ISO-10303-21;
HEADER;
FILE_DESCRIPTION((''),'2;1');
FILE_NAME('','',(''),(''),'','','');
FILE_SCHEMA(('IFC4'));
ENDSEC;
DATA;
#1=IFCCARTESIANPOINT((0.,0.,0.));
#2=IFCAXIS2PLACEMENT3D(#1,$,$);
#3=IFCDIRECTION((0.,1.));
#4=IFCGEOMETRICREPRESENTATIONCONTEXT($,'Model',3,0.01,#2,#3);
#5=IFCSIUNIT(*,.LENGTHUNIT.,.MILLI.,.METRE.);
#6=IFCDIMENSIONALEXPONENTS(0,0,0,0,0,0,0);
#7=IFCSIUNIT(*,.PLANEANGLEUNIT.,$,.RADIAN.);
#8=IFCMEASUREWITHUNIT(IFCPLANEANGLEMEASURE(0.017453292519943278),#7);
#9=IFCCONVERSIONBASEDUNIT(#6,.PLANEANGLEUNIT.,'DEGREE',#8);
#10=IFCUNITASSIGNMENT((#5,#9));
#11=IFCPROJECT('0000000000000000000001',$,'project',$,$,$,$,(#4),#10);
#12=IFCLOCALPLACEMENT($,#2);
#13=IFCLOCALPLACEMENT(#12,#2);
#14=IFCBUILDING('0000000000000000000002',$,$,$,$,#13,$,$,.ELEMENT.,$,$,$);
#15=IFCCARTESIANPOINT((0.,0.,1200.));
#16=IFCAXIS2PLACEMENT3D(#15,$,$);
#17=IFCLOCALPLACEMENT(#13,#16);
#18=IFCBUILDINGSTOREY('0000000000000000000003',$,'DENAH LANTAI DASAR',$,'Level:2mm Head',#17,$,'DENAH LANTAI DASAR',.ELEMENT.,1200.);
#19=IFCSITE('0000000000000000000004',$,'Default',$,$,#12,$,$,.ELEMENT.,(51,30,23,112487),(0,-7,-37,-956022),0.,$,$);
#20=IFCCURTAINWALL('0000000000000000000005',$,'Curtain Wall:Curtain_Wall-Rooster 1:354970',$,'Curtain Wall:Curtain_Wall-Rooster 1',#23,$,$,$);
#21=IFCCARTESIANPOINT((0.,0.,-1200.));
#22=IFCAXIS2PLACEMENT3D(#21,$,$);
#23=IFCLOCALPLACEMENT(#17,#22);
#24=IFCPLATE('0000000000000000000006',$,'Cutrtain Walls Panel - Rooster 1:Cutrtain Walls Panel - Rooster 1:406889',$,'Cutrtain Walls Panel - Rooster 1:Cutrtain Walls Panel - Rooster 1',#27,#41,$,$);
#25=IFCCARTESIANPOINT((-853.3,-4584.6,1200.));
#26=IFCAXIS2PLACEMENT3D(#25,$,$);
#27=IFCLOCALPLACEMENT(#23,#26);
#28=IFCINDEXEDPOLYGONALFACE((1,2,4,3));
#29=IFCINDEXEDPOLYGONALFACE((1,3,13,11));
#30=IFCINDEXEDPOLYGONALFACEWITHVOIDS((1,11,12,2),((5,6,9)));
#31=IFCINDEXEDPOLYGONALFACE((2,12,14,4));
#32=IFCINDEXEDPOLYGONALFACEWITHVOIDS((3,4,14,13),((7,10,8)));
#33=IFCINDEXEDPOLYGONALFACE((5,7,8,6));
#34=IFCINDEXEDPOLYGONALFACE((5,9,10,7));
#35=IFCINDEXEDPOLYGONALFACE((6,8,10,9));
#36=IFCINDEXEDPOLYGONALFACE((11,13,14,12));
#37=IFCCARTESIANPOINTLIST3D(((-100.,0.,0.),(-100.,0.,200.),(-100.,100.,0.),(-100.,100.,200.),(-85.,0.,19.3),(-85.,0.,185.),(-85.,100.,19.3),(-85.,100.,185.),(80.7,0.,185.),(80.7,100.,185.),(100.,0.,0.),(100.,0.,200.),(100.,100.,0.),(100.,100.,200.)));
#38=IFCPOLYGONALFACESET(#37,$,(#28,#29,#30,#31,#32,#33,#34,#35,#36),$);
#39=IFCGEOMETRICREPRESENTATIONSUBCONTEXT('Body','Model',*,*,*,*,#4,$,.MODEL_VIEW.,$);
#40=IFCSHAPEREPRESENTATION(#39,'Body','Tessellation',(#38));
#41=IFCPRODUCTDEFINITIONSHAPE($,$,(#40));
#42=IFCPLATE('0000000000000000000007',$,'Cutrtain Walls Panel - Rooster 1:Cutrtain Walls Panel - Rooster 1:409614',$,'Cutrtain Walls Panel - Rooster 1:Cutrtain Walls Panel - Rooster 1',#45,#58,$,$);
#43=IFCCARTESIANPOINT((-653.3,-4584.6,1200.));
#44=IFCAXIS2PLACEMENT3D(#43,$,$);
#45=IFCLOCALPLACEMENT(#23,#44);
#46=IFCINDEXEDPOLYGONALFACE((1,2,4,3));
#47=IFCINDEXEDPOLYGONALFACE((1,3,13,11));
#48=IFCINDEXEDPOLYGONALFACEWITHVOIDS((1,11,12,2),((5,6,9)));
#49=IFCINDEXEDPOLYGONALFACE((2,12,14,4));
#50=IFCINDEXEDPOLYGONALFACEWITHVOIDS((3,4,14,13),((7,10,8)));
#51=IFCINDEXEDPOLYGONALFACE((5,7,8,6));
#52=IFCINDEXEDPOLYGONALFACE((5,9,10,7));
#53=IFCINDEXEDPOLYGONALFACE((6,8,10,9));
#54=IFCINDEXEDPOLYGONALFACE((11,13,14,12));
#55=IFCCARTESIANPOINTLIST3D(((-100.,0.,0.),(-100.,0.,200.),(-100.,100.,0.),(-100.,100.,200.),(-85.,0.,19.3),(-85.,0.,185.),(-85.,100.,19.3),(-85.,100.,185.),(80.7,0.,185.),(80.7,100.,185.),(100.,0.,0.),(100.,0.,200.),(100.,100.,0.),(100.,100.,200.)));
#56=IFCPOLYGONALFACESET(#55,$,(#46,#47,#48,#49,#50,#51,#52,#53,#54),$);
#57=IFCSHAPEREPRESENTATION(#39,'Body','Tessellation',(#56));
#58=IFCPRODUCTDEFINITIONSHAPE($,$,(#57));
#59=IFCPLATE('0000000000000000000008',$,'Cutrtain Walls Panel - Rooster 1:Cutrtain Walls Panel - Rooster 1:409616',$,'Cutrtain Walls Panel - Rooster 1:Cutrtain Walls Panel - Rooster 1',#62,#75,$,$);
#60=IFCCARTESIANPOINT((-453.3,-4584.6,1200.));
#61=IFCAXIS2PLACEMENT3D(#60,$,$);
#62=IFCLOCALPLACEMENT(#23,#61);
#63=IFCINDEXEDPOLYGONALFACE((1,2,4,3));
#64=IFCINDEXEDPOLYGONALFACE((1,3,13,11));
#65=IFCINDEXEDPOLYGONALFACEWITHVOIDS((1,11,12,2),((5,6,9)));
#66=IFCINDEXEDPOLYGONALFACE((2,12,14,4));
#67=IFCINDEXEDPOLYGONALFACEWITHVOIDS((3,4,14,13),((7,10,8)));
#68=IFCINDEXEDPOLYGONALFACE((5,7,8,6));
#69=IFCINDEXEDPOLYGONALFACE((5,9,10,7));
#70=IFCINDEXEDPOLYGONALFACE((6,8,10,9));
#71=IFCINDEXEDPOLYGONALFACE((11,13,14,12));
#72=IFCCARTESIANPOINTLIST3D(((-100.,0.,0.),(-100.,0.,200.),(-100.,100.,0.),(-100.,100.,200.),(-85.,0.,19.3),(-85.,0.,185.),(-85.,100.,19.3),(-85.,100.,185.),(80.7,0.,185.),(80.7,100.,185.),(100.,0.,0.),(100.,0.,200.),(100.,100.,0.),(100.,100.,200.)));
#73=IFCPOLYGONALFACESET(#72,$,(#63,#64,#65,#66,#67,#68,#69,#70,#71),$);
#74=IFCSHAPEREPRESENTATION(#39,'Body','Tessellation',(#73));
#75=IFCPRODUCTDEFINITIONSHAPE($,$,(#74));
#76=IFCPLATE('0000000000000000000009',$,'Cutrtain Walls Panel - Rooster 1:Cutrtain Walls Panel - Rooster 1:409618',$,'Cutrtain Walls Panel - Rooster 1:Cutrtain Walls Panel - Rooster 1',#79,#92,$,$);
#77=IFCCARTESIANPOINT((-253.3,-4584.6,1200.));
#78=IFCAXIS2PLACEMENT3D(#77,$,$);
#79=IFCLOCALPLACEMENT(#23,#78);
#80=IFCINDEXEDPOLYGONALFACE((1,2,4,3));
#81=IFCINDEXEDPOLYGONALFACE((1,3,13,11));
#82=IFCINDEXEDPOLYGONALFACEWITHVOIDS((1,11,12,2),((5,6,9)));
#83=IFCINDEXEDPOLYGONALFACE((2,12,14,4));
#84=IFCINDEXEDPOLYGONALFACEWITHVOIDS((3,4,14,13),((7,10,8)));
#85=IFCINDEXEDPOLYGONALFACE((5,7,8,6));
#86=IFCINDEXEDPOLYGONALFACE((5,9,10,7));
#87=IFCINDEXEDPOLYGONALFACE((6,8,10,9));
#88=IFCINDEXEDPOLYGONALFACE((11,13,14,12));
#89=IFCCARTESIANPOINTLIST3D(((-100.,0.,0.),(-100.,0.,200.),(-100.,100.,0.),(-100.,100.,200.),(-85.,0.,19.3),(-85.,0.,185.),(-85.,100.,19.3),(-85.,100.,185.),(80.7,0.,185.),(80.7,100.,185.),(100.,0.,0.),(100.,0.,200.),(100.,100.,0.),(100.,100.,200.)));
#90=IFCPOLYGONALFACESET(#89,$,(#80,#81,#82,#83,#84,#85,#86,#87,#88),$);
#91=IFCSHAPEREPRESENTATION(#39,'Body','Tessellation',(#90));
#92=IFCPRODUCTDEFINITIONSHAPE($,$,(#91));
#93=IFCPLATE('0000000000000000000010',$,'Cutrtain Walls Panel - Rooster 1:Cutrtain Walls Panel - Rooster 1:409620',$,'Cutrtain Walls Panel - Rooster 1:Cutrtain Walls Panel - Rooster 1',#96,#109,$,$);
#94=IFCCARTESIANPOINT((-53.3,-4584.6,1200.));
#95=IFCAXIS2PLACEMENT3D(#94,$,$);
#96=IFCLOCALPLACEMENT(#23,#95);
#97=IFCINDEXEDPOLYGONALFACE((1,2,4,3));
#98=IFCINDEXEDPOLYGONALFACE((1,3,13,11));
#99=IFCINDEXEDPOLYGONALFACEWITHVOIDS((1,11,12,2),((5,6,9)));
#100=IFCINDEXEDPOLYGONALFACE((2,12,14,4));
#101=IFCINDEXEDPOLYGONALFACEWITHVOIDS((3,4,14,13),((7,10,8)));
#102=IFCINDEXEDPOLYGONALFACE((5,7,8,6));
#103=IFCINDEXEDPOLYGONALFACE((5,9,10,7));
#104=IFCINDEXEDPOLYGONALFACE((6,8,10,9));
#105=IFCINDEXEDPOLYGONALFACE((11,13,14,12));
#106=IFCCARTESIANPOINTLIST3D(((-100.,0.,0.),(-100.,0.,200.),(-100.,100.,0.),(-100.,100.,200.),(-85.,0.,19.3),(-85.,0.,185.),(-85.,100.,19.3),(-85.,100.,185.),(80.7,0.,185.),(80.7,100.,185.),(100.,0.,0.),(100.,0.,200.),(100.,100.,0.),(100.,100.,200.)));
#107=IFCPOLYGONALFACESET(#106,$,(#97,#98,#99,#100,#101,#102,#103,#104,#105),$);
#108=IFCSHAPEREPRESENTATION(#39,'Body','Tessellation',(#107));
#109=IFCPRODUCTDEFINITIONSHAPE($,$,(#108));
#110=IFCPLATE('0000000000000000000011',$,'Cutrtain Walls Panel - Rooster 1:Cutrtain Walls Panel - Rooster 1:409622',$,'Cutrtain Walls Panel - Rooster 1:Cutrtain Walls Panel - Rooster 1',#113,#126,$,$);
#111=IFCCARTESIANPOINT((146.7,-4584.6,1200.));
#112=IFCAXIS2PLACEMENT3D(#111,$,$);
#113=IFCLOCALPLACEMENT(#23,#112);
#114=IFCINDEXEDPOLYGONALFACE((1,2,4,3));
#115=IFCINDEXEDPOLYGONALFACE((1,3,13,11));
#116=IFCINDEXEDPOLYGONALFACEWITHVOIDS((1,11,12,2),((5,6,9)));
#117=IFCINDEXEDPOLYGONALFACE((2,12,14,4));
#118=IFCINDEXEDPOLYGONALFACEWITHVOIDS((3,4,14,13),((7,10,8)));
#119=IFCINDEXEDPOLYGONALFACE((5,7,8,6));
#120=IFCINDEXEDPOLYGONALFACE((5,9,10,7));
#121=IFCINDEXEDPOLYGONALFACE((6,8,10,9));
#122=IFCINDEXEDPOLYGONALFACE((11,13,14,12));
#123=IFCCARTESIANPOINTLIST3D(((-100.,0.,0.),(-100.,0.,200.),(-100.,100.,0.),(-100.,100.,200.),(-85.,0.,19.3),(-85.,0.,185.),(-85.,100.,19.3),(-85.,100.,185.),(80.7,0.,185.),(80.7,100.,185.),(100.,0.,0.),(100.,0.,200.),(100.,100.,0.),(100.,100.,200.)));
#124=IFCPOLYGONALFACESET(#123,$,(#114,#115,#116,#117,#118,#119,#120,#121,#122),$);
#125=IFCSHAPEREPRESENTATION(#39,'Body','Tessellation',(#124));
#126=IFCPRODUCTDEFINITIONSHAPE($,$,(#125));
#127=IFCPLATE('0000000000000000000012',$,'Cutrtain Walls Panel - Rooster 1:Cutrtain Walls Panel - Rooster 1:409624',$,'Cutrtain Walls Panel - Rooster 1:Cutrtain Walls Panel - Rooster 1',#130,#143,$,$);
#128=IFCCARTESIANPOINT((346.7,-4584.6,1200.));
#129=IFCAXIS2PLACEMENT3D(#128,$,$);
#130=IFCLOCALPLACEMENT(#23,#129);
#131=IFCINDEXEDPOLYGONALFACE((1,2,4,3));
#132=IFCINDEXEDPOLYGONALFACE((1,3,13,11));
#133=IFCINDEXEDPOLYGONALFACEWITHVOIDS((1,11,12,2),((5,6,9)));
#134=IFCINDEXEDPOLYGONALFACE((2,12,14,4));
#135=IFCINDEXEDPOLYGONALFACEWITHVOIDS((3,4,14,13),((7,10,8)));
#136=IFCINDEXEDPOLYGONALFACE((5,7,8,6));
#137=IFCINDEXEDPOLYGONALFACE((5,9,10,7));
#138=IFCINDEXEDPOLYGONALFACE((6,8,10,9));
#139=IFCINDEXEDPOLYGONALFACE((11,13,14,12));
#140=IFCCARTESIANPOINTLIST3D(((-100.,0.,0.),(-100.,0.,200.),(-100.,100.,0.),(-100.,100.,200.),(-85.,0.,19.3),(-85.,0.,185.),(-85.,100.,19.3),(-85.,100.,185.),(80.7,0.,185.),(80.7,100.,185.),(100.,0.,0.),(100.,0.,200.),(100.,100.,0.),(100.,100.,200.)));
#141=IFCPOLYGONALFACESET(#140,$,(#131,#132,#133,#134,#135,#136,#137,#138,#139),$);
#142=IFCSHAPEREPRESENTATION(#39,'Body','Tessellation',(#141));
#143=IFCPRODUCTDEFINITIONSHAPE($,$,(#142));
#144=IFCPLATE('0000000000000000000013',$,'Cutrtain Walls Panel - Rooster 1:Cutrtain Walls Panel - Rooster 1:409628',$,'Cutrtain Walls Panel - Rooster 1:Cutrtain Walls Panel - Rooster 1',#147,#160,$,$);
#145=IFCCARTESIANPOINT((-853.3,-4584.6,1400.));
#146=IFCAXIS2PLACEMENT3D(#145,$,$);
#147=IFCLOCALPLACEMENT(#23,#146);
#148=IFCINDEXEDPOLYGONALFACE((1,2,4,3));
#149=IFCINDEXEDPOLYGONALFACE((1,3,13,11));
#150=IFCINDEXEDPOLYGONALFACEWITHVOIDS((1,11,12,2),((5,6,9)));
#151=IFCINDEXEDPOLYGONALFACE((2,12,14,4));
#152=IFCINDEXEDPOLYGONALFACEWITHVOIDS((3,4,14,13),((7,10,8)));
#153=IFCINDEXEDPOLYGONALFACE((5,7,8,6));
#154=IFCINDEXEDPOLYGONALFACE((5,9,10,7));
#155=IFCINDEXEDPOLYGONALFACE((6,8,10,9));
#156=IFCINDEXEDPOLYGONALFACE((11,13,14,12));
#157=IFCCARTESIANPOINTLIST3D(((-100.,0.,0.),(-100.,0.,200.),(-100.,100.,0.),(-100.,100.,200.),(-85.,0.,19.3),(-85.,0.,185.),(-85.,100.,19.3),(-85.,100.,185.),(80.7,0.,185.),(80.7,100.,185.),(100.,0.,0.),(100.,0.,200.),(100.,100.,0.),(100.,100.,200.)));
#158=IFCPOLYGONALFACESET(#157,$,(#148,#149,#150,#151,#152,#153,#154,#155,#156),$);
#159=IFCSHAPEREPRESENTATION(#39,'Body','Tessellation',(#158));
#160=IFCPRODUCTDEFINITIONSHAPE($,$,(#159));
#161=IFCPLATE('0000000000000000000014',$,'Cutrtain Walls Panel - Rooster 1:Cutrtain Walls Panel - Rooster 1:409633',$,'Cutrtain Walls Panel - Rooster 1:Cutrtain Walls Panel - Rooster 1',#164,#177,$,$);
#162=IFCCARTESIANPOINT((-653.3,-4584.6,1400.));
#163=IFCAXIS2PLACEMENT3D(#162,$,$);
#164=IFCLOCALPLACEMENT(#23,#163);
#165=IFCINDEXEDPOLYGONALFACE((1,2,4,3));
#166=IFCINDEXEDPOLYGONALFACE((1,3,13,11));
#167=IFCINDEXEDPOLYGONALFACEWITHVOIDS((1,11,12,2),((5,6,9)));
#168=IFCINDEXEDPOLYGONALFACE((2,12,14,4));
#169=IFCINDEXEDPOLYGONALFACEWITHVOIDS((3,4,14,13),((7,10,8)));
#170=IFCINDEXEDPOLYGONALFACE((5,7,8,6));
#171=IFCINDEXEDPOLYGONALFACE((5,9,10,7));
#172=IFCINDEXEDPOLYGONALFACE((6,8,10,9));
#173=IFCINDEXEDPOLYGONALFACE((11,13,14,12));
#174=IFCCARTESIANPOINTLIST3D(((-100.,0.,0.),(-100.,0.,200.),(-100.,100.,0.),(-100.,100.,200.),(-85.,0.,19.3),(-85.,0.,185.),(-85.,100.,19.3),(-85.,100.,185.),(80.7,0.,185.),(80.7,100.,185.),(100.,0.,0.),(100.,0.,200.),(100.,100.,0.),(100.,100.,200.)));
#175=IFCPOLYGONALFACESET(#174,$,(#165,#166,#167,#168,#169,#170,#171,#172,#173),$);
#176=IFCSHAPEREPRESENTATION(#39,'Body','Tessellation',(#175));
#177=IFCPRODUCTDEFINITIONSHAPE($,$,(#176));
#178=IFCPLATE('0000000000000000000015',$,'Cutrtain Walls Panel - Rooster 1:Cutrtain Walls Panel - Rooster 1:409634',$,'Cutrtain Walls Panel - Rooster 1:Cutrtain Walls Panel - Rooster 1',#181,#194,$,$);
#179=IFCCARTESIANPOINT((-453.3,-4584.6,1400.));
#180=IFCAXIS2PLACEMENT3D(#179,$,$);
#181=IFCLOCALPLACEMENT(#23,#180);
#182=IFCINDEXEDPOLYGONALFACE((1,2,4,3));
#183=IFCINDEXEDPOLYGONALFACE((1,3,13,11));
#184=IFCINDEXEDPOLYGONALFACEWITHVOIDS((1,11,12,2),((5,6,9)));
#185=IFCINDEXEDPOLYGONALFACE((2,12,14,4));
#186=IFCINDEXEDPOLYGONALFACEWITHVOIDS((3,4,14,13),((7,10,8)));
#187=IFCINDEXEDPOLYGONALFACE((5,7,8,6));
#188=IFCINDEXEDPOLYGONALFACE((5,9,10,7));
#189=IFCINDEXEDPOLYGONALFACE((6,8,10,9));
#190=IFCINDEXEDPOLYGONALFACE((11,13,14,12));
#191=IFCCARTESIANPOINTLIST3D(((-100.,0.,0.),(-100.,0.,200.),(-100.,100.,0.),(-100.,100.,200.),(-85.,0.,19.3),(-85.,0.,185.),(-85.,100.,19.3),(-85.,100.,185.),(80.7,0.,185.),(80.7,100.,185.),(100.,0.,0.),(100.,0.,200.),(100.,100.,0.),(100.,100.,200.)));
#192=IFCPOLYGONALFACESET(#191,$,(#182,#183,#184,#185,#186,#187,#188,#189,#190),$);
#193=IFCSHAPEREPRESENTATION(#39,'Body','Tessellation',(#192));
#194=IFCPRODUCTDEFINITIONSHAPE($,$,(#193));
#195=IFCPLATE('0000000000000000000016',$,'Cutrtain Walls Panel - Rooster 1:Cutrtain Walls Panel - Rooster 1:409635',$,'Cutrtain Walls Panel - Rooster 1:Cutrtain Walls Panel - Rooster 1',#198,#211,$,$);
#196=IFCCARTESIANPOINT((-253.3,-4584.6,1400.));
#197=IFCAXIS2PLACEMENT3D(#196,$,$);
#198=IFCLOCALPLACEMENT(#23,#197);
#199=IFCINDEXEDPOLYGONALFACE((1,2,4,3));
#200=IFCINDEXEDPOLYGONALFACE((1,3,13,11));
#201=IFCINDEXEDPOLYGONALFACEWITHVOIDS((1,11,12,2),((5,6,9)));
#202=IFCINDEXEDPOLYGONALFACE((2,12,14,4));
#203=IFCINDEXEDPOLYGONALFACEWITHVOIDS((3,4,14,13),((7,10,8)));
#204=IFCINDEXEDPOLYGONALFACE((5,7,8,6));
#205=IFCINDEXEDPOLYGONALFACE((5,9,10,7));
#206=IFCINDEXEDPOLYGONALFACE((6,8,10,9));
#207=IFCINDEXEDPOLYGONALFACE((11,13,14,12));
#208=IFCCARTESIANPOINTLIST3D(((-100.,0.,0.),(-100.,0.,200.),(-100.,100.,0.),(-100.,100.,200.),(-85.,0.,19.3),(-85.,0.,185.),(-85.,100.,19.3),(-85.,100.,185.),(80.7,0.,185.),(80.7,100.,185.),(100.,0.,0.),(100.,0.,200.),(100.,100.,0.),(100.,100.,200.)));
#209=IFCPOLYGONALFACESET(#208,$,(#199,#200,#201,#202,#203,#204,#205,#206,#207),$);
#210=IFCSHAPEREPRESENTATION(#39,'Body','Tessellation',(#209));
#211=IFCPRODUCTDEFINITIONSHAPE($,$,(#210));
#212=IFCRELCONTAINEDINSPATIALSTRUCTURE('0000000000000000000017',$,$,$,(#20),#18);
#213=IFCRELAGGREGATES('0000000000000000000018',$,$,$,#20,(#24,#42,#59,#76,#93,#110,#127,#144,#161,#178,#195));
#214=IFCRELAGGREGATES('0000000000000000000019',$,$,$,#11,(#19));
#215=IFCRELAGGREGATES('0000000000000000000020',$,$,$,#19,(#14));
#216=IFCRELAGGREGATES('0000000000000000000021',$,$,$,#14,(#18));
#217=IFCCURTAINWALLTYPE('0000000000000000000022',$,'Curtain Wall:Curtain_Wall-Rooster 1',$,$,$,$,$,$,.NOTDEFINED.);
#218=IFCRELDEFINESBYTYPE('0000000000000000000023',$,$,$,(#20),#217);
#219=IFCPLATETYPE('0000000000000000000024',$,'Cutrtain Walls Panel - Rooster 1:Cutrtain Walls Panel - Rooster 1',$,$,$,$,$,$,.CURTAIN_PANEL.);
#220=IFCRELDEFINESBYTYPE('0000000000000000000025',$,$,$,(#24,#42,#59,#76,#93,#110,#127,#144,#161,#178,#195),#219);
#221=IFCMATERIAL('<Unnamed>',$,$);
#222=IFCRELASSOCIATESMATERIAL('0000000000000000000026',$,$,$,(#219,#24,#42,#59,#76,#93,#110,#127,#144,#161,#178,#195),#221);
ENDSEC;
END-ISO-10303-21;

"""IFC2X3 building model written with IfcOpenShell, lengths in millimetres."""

from ifc_helpers import new_model, entity, si_unit, converted_unit, direction, frame, origin, place, context, subcontext, project, spatial, polyline, outline, extrude, source, transform, mapped, material, type_object, type_shapes, element, aggregate, save


model = new_model("IFC2X3")

# Units and contexts
model_context = context("Model", 3, precision=0.01, world=origin(), true_north=direction((0.0, 1.0)))
body_context = subcontext(model_context, "Body", "Model", "MODEL_VIEW")
ifc_project = project(units=[si_unit("LENGTHUNIT", "METRE", prefix="MILLI"), converted_unit("PLANEANGLEUNIT", "DEGREE", entity("IfcPlaneAngleMeasure", 0.017453292519943278), si_unit("PLANEANGLEUNIT", "RADIAN"), dimensions=[0, 0, 0, 0, 0, 0, 0])], contexts=[model_context])

# Site, building, storey
site_placement = place(None, origin())
site = spatial("IfcSite", under=ifc_project, at=site_placement, Name="Default", CompositionType="ELEMENT", RefLatitude=(51, 30, 23, 112487), RefLongitude=(0, -7, -37, -956022), RefElevation=0.0)
building_placement = place(site_placement, origin())
building = spatial("IfcBuilding", under=site, at=building_placement, CompositionType="ELEMENT")
storey_placement = place(building_placement, frame((0.0, 0.0, 1200.0)))
storey = spatial("IfcBuildingStorey", under=building, at=storey_placement, Name="DENAH LANTAI DASAR", ObjectType="Level:2mm Head", LongName="DENAH LANTAI DASAR", CompositionType="ELEMENT", Elevation=1200.0)

# Curtain wall, plates
curtain_wall_type = type_object("IfcCurtainWallType", Name="Curtain Wall:Curtain_Wall-Rooster 1", PredefinedType="NOTDEFINED")
curtain_wall_1_placement = place(storey_placement, frame((0.0, 0.0, -1200.0)))
curtain_wall_1 = element("IfcCurtainWall", 1, at=curtain_wall_1_placement, inside=storey, type_object=curtain_wall_type, Name="Curtain Wall:Curtain_Wall-Rooster 1:354970", ObjectType="Curtain Wall:Curtain_Wall-Rooster 1")
ifc_material_1 = material(Name="<Unnamed>")
plate_type_1 = type_object("IfcPlateType", Name="Cutrtain Walls Panel - Rooster 1:Cutrtain Walls Panel - Rooster 1", PredefinedType="CURTAIN_PANEL", material=ifc_material_1)
shared_shape_1 = source(origin(), body_context, "Body", "SweptSolid", [
    extrude(outline(polyline([(-100.0, -100.0), (100.0, -100.0), (100.0, 100.0), (-100.0, 100.0), (-100.0, -100.0)]), holes=[polyline([(80.7, 85.0), (-85.0, -80.7), (-85.0, 85.0), (80.7, 85.0)])]), frame((0.0, 0.0, 100.0), z_axis=(0.0, 1.0, 0.0), x_axis=(0.0, 0.0, -1.0)), (0.0, 0.0, 1.0), 100.0),
])
type_shapes(plate_type_1, [shared_shape_1])
plate_1_placement = place(curtain_wall_1_placement, frame((-853.3, -4584.6, 1200.0)))
plate_1 = element("IfcPlate", 2, at=plate_1_placement, type_object=plate_type_1, material=ifc_material_1, Name="Cutrtain Walls Panel - Rooster 1:Cutrtain Walls Panel - Rooster 1:406889", ObjectType="Cutrtain Walls Panel - Rooster 1:Cutrtain Walls Panel - Rooster 1", context=body_context, shape_type="MappedRepresentation", body=[
    mapped(shared_shape_1, transform((0.0, 0.0, 0.0), scale=1.0)),
])
plate_2_placement = place(curtain_wall_1_placement, frame((-653.3, -4584.6, 1200.0)))
plate_2 = element("IfcPlate", 3, at=plate_2_placement, type_object=plate_type_1, material=ifc_material_1, Name="Cutrtain Walls Panel - Rooster 1:Cutrtain Walls Panel - Rooster 1:409614", ObjectType="Cutrtain Walls Panel - Rooster 1:Cutrtain Walls Panel - Rooster 1", context=body_context, shape_type="MappedRepresentation", body=[
    mapped(shared_shape_1, transform((0.0, 0.0, 0.0), scale=1.0)),
])
plate_3_placement = place(curtain_wall_1_placement, frame((-453.3, -4584.6, 1200.0)))
plate_3 = element("IfcPlate", 4, at=plate_3_placement, type_object=plate_type_1, material=ifc_material_1, Name="Cutrtain Walls Panel - Rooster 1:Cutrtain Walls Panel - Rooster 1:409616", ObjectType="Cutrtain Walls Panel - Rooster 1:Cutrtain Walls Panel - Rooster 1", context=body_context, shape_type="MappedRepresentation", body=[
    mapped(shared_shape_1, transform((0.0, 0.0, 0.0), scale=1.0)),
])
plate_4_placement = place(curtain_wall_1_placement, frame((-253.3, -4584.6, 1200.0)))
plate_4 = element("IfcPlate", 5, at=plate_4_placement, type_object=plate_type_1, material=ifc_material_1, Name="Cutrtain Walls Panel - Rooster 1:Cutrtain Walls Panel - Rooster 1:409618", ObjectType="Cutrtain Walls Panel - Rooster 1:Cutrtain Walls Panel - Rooster 1", context=body_context, shape_type="MappedRepresentation", body=[
    mapped(shared_shape_1, transform((0.0, 0.0, 0.0), scale=1.0)),
])
plate_5_placement = place(curtain_wall_1_placement, frame((-53.3, -4584.6, 1200.0)))
plate_5 = element("IfcPlate", 6, at=plate_5_placement, type_object=plate_type_1, material=ifc_material_1, Name="Cutrtain Walls Panel - Rooster 1:Cutrtain Walls Panel - Rooster 1:409620", ObjectType="Cutrtain Walls Panel - Rooster 1:Cutrtain Walls Panel - Rooster 1", context=body_context, shape_type="MappedRepresentation", body=[
    mapped(shared_shape_1, transform((0.0, 0.0, 0.0), scale=1.0)),
])
plate_6_placement = place(curtain_wall_1_placement, frame((146.7, -4584.6, 1200.0)))
plate_6 = element("IfcPlate", 7, at=plate_6_placement, type_object=plate_type_1, material=ifc_material_1, Name="Cutrtain Walls Panel - Rooster 1:Cutrtain Walls Panel - Rooster 1:409622", ObjectType="Cutrtain Walls Panel - Rooster 1:Cutrtain Walls Panel - Rooster 1", context=body_context, shape_type="MappedRepresentation", body=[
    mapped(shared_shape_1, transform((0.0, 0.0, 0.0), scale=1.0)),
])
plate_7_placement = place(curtain_wall_1_placement, frame((346.7, -4584.6, 1200.0)))
plate_7 = element("IfcPlate", 8, at=plate_7_placement, type_object=plate_type_1, material=ifc_material_1, Name="Cutrtain Walls Panel - Rooster 1:Cutrtain Walls Panel - Rooster 1:409624", ObjectType="Cutrtain Walls Panel - Rooster 1:Cutrtain Walls Panel - Rooster 1", context=body_context, shape_type="MappedRepresentation", body=[
    mapped(shared_shape_1, transform((0.0, 0.0, 0.0), scale=1.0)),
])
plate_8_placement = place(curtain_wall_1_placement, frame((-853.3, -4584.6, 1400.0)))
plate_8 = element("IfcPlate", 9, at=plate_8_placement, type_object=plate_type_1, material=ifc_material_1, Name="Cutrtain Walls Panel - Rooster 1:Cutrtain Walls Panel - Rooster 1:409628", ObjectType="Cutrtain Walls Panel - Rooster 1:Cutrtain Walls Panel - Rooster 1", context=body_context, shape_type="MappedRepresentation", body=[
    mapped(shared_shape_1, transform((0.0, 0.0, 0.0), scale=1.0)),
])
plate_9_placement = place(curtain_wall_1_placement, frame((-653.3, -4584.6, 1400.0)))
plate_9 = element("IfcPlate", 10, at=plate_9_placement, type_object=plate_type_1, material=ifc_material_1, Name="Cutrtain Walls Panel - Rooster 1:Cutrtain Walls Panel - Rooster 1:409633", ObjectType="Cutrtain Walls Panel - Rooster 1:Cutrtain Walls Panel - Rooster 1", context=body_context, shape_type="MappedRepresentation", body=[
    mapped(shared_shape_1, transform((0.0, 0.0, 0.0), scale=1.0)),
])
plate_10_placement = place(curtain_wall_1_placement, frame((-453.3, -4584.6, 1400.0)))
plate_10 = element("IfcPlate", 11, at=plate_10_placement, type_object=plate_type_1, material=ifc_material_1, Name="Cutrtain Walls Panel - Rooster 1:Cutrtain Walls Panel - Rooster 1:409634", ObjectType="Cutrtain Walls Panel - Rooster 1:Cutrtain Walls Panel - Rooster 1", context=body_context, shape_type="MappedRepresentation", body=[
    mapped(shared_shape_1, transform((0.0, 0.0, 0.0), scale=1.0)),
])
plate_11_placement = place(curtain_wall_1_placement, frame((-253.3, -4584.6, 1400.0)))
plate_11 = element("IfcPlate", 12, at=plate_11_placement, type_object=plate_type_1, material=ifc_material_1, Name="Cutrtain Walls Panel - Rooster 1:Cutrtain Walls Panel - Rooster 1:409635", ObjectType="Cutrtain Walls Panel - Rooster 1:Cutrtain Walls Panel - Rooster 1", context=body_context, shape_type="MappedRepresentation", body=[
    mapped(shared_shape_1, transform((0.0, 0.0, 0.0), scale=1.0)),
])

aggregate(curtain_wall_1, [plate_1, plate_2, plate_3, plate_4, plate_5, plate_6, plate_7, plate_8, plate_9, plate_10, plate_11])

save(model, "model.ifc")
